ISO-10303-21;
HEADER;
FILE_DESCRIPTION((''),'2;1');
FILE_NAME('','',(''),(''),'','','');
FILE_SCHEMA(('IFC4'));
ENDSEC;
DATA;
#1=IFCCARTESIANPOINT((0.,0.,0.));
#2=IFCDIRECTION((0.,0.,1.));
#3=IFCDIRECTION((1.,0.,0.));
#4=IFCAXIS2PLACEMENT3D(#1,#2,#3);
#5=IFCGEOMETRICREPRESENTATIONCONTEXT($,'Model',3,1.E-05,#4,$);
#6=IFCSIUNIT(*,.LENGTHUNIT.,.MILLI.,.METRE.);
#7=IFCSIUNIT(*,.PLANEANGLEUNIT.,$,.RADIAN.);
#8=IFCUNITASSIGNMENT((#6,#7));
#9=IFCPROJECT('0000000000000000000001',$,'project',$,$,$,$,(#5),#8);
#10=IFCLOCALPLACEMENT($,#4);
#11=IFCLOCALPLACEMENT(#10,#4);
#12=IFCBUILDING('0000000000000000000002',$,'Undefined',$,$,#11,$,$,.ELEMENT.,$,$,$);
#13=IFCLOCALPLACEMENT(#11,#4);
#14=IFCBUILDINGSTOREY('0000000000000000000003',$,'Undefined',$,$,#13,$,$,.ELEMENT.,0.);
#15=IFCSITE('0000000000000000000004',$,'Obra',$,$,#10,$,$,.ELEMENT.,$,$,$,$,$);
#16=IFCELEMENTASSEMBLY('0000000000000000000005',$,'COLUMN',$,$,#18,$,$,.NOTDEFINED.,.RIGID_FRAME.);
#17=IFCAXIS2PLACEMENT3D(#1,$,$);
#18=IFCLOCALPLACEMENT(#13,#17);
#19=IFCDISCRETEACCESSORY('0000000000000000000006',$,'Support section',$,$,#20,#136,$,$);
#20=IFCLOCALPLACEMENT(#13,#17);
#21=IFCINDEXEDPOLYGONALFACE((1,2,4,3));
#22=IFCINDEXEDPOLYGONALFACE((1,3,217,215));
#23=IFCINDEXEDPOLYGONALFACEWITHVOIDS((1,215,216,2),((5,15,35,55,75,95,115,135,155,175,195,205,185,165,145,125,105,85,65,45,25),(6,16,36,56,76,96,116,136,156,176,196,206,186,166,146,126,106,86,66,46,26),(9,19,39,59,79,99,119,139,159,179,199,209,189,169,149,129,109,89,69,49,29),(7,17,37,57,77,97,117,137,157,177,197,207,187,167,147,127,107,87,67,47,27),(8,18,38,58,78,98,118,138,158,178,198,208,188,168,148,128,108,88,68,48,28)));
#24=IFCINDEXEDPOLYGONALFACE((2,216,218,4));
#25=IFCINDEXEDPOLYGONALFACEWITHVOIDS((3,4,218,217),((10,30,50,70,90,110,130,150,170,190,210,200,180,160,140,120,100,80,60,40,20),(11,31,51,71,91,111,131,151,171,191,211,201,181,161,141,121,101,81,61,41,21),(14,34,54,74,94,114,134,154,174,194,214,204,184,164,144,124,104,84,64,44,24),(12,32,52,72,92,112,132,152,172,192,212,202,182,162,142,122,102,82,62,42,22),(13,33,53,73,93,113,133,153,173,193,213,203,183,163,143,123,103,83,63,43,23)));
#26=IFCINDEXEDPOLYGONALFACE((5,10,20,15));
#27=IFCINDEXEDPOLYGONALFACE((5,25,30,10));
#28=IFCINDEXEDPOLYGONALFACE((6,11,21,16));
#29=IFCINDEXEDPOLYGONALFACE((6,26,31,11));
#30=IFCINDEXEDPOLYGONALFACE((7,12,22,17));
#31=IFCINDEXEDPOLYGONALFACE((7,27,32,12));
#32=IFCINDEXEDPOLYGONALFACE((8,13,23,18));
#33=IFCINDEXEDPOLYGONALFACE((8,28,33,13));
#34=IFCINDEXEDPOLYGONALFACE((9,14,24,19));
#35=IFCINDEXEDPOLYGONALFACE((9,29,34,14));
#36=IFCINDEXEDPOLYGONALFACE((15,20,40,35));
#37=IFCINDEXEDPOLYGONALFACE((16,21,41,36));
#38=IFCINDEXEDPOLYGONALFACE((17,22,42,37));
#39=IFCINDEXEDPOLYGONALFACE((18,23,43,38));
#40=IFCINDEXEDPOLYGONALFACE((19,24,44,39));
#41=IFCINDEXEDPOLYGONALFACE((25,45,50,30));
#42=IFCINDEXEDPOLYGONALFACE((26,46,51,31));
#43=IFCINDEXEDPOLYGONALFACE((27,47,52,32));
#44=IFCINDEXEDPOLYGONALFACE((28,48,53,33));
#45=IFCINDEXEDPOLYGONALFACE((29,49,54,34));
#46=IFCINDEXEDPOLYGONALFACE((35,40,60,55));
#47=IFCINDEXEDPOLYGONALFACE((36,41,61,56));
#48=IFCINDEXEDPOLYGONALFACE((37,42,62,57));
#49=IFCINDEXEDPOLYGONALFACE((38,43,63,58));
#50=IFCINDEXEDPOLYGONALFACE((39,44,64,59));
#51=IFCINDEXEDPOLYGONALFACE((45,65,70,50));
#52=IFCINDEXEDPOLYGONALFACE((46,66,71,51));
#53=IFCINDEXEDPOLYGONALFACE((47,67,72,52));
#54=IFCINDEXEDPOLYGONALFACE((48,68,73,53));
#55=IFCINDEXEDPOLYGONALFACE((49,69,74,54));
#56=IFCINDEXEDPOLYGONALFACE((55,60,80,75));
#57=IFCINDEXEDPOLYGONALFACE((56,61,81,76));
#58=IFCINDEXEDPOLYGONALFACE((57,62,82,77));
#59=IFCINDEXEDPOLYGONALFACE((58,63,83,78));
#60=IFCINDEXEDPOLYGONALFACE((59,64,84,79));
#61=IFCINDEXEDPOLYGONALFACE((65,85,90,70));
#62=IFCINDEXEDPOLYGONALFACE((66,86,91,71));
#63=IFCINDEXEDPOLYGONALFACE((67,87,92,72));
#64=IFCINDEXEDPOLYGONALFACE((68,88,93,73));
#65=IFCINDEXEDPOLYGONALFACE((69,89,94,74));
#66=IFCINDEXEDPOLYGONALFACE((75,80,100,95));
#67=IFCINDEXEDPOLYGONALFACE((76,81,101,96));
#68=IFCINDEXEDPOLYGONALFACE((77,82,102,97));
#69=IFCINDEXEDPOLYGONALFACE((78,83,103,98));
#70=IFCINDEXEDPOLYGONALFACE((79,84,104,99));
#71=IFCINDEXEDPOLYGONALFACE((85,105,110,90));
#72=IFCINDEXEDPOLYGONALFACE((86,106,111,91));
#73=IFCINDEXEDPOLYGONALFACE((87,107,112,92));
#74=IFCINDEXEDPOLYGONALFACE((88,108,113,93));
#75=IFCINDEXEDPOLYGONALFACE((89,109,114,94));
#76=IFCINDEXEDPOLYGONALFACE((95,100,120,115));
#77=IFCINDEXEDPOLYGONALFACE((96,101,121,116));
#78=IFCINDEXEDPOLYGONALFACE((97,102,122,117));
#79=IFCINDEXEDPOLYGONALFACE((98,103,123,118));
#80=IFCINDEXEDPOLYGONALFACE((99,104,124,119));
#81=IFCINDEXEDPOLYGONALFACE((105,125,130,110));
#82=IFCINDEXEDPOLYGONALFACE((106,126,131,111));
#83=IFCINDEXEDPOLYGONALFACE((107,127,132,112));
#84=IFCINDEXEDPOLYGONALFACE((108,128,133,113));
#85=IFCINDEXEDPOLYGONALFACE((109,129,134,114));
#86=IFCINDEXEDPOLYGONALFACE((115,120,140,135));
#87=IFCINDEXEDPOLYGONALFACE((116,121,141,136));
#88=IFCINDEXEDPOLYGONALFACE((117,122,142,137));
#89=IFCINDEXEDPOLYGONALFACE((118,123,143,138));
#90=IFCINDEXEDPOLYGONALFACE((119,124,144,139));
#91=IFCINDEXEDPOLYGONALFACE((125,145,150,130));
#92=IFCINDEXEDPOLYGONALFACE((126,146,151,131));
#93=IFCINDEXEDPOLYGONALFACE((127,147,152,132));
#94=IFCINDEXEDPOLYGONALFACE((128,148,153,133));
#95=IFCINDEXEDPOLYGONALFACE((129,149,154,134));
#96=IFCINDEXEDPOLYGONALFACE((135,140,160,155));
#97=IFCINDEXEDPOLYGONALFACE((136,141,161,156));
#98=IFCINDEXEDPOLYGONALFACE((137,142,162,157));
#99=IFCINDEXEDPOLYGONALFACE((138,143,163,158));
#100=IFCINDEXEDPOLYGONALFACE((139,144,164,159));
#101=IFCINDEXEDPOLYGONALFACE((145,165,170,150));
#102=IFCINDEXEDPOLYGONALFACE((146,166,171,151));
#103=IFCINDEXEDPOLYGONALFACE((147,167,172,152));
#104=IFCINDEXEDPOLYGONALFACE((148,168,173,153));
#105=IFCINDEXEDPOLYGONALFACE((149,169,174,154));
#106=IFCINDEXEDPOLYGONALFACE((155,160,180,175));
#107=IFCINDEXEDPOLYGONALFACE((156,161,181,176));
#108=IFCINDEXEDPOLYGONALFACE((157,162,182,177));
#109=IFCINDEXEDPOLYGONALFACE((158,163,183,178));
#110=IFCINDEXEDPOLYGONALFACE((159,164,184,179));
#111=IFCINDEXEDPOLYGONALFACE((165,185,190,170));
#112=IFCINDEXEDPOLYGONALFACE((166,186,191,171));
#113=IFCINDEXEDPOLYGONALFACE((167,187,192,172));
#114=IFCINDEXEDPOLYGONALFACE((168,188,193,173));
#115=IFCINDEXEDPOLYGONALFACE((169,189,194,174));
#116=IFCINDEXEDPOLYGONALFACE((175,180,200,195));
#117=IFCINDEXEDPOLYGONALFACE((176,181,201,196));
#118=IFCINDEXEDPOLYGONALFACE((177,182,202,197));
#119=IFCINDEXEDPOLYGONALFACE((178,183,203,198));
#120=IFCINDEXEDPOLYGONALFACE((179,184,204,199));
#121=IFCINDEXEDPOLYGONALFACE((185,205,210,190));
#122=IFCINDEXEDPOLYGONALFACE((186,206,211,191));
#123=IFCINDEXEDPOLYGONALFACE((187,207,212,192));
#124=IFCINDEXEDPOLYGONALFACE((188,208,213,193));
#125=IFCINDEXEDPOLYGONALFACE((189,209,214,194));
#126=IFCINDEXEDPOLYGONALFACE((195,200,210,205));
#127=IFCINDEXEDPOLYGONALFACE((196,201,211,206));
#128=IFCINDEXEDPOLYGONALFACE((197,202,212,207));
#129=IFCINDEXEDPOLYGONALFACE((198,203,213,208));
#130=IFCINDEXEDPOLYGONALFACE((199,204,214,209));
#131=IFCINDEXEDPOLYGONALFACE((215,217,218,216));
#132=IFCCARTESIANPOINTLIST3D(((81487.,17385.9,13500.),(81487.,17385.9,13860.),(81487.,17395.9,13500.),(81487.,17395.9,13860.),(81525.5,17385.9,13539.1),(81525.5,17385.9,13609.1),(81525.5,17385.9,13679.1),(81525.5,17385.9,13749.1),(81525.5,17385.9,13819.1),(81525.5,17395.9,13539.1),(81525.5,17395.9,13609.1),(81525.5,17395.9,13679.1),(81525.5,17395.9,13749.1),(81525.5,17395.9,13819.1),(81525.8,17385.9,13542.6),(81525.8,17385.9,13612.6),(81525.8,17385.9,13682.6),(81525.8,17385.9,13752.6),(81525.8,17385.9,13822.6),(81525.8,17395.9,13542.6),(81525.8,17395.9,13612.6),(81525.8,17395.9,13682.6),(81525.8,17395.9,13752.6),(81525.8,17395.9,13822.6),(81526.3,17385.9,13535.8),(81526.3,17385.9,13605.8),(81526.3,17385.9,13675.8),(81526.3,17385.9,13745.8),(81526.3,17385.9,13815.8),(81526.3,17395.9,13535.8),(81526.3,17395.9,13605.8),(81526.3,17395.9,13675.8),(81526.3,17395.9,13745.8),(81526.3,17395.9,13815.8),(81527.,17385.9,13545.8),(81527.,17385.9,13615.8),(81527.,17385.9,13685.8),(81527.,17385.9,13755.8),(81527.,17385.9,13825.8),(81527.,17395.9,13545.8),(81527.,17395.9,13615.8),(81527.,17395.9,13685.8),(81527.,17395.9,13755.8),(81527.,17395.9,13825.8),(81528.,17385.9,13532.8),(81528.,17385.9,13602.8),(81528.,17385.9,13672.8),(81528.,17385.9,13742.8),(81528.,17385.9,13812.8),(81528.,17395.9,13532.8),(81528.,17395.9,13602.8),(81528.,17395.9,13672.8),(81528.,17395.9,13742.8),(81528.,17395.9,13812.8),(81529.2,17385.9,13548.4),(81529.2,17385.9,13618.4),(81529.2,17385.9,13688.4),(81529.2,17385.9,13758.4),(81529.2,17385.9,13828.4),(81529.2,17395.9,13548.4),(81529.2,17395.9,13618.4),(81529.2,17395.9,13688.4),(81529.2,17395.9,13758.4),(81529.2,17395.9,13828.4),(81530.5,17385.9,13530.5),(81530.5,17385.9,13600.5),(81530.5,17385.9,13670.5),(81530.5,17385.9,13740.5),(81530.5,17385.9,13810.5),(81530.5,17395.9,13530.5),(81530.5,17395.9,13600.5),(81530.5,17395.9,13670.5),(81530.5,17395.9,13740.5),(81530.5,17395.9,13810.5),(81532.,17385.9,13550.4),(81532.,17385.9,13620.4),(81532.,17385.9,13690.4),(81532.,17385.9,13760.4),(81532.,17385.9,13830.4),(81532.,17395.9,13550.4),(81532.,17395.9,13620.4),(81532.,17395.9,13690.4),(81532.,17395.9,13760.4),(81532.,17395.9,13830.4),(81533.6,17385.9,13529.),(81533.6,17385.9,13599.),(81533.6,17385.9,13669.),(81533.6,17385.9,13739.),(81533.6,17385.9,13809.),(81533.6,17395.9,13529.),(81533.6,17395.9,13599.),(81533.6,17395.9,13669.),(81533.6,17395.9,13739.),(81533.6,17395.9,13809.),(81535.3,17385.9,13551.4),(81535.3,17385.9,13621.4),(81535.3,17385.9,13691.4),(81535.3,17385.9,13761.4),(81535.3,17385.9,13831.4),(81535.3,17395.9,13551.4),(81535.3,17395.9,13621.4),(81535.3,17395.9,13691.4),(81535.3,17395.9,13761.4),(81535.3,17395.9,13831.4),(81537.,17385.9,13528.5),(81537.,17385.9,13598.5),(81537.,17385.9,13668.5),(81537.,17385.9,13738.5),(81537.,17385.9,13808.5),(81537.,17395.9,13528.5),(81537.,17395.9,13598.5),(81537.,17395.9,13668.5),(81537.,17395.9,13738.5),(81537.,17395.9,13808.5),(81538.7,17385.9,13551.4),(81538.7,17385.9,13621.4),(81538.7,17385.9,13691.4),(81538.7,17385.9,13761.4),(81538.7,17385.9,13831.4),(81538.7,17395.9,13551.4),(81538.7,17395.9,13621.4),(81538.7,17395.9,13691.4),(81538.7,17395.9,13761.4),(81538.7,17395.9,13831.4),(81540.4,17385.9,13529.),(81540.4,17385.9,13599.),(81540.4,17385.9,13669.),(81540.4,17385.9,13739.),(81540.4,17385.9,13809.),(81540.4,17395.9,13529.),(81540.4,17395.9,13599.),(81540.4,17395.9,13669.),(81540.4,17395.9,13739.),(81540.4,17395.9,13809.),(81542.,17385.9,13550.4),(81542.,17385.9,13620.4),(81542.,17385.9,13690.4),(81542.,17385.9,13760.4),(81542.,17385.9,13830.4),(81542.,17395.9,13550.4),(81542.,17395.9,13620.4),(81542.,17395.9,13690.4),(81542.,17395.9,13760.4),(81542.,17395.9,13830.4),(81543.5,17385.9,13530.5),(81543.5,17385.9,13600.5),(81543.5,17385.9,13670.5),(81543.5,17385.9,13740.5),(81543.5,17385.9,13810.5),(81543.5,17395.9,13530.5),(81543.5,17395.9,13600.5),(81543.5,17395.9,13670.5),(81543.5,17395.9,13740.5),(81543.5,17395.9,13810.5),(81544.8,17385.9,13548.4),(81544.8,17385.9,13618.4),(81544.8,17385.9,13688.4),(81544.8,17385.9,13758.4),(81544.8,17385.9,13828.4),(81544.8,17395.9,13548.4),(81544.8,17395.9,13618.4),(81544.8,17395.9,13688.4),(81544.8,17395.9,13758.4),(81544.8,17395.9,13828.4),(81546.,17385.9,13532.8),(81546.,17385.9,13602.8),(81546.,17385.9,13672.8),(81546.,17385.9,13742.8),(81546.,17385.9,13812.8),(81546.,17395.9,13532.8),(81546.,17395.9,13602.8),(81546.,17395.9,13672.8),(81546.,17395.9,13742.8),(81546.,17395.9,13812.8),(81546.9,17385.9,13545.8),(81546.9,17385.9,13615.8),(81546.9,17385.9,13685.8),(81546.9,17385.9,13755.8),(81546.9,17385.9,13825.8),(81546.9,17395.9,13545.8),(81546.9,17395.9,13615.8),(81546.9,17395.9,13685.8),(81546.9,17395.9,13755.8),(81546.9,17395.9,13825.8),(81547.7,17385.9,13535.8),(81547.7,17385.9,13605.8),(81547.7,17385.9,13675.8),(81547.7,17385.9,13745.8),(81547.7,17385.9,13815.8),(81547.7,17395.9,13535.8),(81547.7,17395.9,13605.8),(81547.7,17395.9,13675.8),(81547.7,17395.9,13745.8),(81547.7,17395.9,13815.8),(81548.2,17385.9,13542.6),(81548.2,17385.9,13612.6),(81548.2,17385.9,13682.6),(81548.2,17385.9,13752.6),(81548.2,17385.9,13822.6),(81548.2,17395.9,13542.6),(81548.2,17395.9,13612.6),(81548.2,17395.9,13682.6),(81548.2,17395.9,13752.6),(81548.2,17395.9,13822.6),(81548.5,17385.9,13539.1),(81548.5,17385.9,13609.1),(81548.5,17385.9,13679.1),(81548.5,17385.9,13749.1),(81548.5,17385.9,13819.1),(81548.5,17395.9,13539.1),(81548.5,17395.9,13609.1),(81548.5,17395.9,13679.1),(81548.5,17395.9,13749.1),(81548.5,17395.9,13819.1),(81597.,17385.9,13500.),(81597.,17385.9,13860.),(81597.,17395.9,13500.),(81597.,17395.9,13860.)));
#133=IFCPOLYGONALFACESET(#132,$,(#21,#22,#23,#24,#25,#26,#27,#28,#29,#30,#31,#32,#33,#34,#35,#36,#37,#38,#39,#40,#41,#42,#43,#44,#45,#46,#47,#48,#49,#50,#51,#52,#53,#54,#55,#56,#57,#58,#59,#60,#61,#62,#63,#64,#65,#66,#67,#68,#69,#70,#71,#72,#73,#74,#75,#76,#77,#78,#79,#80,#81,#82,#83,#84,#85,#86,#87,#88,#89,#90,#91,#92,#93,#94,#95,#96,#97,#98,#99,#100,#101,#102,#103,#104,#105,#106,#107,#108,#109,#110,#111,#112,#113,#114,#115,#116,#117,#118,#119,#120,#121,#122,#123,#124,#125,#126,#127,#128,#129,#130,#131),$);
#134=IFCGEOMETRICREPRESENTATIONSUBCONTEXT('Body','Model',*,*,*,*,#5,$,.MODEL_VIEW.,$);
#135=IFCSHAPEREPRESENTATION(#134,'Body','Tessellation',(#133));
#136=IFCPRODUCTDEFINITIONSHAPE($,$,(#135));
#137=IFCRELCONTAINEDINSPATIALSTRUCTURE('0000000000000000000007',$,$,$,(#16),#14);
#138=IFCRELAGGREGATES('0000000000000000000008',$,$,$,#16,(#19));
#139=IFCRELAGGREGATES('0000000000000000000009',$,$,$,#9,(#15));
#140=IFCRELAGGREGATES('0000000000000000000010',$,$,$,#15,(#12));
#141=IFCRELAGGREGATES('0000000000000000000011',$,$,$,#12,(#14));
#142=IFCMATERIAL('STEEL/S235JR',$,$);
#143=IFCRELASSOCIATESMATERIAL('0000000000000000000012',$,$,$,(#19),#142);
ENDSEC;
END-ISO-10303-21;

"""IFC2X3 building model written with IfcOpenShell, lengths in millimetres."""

from ifc_helpers import new_model, si_unit, frame, origin_with_axes, origin_2d_with_axis, place, context, subcontext, project, spatial, rectangle, circle, extrude, source, transform, mapped, material, element, aggregate, save


model = new_model("IFC2X3")

# Units and contexts
model_context = context("Model", 3, precision=1e-05, world=origin_with_axes())
body_context = subcontext(model_context, "Body", "Model", "MODEL_VIEW")
ifc_project = project(units=[si_unit("LENGTHUNIT", "METRE", prefix="MILLI"), si_unit("PLANEANGLEUNIT", "RADIAN")], contexts=[model_context])

# Site, building, storey
site_placement = place(None, origin_with_axes())
site = spatial("IfcSite", under=ifc_project, at=site_placement, Name="Obra", CompositionType="ELEMENT")
building_placement = place(site_placement, origin_with_axes())
building = spatial("IfcBuilding", under=site, at=building_placement, Name="Undefined", CompositionType="ELEMENT")
storey_placement = place(building_placement, origin_with_axes())
storey = spatial("IfcBuildingStorey", under=building, at=storey_placement, Name="Undefined", CompositionType="ELEMENT", Elevation=0.0)

# Element assembly
assembly_1_placement = place(storey_placement, origin_with_axes())
assembly_1 = element("IfcElementAssembly", 1, at=assembly_1_placement, inside=storey, Name="COLUMN", AssemblyPlace="NOTDEFINED", PredefinedType="RIGID_FRAME")
ifc_material_1 = material(Name="STEEL/S235JR")

# Discrete accessory, opening
shared_shape_1 = source(origin_with_axes(), body_context, "Body", "SweptSolid", [
    extrude(circle(Radius=11.5, at=origin_2d_with_axis()), frame((0.0, -15.8, 0.0), z_axis=(0.0, 1.0, 0.0), x_axis=(1.0, 0.0, 0.0)), (0.0, 0.0, 1.0), 10.2),
])
discrete_accessory_1_placement = place(assembly_1_placement, frame((81542.0, 17390.9, 13500.0), z_axis=(0.0, 0.0, 1.0), x_axis=(1.0, 0.0, 0.0)))
discrete_accessory_1 = element("IfcDiscreteAccessory", 2, at=discrete_accessory_1_placement, material=ifc_material_1, Name="Support section", context=body_context, shape_type="SweptSolid", body=[
    extrude(rectangle(XDim=10.0, YDim=110.0, at=origin_2d_with_axis()), frame((0.0, 0.0, 360.0), z_axis=(0.0, 0.0, -1.0), x_axis=(0.0, 1.0, 0.0)), (0.0, 0.0, 1.0), 360.0),
])
opening_1_placement = place(assembly_1_placement, frame((81587.0, 17380.1, 13900.0), z_axis=(-1.0, 0.0, 0.0), x_axis=(0.0, 0.0, -1.0)))
element("IfcOpeningElement", 3, at=opening_1_placement, cuts=discrete_accessory_1, ObjectType="Opening", context=body_context, shape_type="MappedRepresentation", body=[
    mapped(shared_shape_1, transform((80.0, 0.0, 50.0))),
    mapped(shared_shape_1, transform((150.0, 0.0, 50.0))),
    mapped(shared_shape_1, transform((220.0, 0.0, 50.0))),
    mapped(shared_shape_1, transform((290.0, 0.0, 50.0))),
    mapped(shared_shape_1, transform((360.0, 0.0, 50.0))),
])
aggregate(assembly_1, [discrete_accessory_1])

save(model, "model.ifc")
